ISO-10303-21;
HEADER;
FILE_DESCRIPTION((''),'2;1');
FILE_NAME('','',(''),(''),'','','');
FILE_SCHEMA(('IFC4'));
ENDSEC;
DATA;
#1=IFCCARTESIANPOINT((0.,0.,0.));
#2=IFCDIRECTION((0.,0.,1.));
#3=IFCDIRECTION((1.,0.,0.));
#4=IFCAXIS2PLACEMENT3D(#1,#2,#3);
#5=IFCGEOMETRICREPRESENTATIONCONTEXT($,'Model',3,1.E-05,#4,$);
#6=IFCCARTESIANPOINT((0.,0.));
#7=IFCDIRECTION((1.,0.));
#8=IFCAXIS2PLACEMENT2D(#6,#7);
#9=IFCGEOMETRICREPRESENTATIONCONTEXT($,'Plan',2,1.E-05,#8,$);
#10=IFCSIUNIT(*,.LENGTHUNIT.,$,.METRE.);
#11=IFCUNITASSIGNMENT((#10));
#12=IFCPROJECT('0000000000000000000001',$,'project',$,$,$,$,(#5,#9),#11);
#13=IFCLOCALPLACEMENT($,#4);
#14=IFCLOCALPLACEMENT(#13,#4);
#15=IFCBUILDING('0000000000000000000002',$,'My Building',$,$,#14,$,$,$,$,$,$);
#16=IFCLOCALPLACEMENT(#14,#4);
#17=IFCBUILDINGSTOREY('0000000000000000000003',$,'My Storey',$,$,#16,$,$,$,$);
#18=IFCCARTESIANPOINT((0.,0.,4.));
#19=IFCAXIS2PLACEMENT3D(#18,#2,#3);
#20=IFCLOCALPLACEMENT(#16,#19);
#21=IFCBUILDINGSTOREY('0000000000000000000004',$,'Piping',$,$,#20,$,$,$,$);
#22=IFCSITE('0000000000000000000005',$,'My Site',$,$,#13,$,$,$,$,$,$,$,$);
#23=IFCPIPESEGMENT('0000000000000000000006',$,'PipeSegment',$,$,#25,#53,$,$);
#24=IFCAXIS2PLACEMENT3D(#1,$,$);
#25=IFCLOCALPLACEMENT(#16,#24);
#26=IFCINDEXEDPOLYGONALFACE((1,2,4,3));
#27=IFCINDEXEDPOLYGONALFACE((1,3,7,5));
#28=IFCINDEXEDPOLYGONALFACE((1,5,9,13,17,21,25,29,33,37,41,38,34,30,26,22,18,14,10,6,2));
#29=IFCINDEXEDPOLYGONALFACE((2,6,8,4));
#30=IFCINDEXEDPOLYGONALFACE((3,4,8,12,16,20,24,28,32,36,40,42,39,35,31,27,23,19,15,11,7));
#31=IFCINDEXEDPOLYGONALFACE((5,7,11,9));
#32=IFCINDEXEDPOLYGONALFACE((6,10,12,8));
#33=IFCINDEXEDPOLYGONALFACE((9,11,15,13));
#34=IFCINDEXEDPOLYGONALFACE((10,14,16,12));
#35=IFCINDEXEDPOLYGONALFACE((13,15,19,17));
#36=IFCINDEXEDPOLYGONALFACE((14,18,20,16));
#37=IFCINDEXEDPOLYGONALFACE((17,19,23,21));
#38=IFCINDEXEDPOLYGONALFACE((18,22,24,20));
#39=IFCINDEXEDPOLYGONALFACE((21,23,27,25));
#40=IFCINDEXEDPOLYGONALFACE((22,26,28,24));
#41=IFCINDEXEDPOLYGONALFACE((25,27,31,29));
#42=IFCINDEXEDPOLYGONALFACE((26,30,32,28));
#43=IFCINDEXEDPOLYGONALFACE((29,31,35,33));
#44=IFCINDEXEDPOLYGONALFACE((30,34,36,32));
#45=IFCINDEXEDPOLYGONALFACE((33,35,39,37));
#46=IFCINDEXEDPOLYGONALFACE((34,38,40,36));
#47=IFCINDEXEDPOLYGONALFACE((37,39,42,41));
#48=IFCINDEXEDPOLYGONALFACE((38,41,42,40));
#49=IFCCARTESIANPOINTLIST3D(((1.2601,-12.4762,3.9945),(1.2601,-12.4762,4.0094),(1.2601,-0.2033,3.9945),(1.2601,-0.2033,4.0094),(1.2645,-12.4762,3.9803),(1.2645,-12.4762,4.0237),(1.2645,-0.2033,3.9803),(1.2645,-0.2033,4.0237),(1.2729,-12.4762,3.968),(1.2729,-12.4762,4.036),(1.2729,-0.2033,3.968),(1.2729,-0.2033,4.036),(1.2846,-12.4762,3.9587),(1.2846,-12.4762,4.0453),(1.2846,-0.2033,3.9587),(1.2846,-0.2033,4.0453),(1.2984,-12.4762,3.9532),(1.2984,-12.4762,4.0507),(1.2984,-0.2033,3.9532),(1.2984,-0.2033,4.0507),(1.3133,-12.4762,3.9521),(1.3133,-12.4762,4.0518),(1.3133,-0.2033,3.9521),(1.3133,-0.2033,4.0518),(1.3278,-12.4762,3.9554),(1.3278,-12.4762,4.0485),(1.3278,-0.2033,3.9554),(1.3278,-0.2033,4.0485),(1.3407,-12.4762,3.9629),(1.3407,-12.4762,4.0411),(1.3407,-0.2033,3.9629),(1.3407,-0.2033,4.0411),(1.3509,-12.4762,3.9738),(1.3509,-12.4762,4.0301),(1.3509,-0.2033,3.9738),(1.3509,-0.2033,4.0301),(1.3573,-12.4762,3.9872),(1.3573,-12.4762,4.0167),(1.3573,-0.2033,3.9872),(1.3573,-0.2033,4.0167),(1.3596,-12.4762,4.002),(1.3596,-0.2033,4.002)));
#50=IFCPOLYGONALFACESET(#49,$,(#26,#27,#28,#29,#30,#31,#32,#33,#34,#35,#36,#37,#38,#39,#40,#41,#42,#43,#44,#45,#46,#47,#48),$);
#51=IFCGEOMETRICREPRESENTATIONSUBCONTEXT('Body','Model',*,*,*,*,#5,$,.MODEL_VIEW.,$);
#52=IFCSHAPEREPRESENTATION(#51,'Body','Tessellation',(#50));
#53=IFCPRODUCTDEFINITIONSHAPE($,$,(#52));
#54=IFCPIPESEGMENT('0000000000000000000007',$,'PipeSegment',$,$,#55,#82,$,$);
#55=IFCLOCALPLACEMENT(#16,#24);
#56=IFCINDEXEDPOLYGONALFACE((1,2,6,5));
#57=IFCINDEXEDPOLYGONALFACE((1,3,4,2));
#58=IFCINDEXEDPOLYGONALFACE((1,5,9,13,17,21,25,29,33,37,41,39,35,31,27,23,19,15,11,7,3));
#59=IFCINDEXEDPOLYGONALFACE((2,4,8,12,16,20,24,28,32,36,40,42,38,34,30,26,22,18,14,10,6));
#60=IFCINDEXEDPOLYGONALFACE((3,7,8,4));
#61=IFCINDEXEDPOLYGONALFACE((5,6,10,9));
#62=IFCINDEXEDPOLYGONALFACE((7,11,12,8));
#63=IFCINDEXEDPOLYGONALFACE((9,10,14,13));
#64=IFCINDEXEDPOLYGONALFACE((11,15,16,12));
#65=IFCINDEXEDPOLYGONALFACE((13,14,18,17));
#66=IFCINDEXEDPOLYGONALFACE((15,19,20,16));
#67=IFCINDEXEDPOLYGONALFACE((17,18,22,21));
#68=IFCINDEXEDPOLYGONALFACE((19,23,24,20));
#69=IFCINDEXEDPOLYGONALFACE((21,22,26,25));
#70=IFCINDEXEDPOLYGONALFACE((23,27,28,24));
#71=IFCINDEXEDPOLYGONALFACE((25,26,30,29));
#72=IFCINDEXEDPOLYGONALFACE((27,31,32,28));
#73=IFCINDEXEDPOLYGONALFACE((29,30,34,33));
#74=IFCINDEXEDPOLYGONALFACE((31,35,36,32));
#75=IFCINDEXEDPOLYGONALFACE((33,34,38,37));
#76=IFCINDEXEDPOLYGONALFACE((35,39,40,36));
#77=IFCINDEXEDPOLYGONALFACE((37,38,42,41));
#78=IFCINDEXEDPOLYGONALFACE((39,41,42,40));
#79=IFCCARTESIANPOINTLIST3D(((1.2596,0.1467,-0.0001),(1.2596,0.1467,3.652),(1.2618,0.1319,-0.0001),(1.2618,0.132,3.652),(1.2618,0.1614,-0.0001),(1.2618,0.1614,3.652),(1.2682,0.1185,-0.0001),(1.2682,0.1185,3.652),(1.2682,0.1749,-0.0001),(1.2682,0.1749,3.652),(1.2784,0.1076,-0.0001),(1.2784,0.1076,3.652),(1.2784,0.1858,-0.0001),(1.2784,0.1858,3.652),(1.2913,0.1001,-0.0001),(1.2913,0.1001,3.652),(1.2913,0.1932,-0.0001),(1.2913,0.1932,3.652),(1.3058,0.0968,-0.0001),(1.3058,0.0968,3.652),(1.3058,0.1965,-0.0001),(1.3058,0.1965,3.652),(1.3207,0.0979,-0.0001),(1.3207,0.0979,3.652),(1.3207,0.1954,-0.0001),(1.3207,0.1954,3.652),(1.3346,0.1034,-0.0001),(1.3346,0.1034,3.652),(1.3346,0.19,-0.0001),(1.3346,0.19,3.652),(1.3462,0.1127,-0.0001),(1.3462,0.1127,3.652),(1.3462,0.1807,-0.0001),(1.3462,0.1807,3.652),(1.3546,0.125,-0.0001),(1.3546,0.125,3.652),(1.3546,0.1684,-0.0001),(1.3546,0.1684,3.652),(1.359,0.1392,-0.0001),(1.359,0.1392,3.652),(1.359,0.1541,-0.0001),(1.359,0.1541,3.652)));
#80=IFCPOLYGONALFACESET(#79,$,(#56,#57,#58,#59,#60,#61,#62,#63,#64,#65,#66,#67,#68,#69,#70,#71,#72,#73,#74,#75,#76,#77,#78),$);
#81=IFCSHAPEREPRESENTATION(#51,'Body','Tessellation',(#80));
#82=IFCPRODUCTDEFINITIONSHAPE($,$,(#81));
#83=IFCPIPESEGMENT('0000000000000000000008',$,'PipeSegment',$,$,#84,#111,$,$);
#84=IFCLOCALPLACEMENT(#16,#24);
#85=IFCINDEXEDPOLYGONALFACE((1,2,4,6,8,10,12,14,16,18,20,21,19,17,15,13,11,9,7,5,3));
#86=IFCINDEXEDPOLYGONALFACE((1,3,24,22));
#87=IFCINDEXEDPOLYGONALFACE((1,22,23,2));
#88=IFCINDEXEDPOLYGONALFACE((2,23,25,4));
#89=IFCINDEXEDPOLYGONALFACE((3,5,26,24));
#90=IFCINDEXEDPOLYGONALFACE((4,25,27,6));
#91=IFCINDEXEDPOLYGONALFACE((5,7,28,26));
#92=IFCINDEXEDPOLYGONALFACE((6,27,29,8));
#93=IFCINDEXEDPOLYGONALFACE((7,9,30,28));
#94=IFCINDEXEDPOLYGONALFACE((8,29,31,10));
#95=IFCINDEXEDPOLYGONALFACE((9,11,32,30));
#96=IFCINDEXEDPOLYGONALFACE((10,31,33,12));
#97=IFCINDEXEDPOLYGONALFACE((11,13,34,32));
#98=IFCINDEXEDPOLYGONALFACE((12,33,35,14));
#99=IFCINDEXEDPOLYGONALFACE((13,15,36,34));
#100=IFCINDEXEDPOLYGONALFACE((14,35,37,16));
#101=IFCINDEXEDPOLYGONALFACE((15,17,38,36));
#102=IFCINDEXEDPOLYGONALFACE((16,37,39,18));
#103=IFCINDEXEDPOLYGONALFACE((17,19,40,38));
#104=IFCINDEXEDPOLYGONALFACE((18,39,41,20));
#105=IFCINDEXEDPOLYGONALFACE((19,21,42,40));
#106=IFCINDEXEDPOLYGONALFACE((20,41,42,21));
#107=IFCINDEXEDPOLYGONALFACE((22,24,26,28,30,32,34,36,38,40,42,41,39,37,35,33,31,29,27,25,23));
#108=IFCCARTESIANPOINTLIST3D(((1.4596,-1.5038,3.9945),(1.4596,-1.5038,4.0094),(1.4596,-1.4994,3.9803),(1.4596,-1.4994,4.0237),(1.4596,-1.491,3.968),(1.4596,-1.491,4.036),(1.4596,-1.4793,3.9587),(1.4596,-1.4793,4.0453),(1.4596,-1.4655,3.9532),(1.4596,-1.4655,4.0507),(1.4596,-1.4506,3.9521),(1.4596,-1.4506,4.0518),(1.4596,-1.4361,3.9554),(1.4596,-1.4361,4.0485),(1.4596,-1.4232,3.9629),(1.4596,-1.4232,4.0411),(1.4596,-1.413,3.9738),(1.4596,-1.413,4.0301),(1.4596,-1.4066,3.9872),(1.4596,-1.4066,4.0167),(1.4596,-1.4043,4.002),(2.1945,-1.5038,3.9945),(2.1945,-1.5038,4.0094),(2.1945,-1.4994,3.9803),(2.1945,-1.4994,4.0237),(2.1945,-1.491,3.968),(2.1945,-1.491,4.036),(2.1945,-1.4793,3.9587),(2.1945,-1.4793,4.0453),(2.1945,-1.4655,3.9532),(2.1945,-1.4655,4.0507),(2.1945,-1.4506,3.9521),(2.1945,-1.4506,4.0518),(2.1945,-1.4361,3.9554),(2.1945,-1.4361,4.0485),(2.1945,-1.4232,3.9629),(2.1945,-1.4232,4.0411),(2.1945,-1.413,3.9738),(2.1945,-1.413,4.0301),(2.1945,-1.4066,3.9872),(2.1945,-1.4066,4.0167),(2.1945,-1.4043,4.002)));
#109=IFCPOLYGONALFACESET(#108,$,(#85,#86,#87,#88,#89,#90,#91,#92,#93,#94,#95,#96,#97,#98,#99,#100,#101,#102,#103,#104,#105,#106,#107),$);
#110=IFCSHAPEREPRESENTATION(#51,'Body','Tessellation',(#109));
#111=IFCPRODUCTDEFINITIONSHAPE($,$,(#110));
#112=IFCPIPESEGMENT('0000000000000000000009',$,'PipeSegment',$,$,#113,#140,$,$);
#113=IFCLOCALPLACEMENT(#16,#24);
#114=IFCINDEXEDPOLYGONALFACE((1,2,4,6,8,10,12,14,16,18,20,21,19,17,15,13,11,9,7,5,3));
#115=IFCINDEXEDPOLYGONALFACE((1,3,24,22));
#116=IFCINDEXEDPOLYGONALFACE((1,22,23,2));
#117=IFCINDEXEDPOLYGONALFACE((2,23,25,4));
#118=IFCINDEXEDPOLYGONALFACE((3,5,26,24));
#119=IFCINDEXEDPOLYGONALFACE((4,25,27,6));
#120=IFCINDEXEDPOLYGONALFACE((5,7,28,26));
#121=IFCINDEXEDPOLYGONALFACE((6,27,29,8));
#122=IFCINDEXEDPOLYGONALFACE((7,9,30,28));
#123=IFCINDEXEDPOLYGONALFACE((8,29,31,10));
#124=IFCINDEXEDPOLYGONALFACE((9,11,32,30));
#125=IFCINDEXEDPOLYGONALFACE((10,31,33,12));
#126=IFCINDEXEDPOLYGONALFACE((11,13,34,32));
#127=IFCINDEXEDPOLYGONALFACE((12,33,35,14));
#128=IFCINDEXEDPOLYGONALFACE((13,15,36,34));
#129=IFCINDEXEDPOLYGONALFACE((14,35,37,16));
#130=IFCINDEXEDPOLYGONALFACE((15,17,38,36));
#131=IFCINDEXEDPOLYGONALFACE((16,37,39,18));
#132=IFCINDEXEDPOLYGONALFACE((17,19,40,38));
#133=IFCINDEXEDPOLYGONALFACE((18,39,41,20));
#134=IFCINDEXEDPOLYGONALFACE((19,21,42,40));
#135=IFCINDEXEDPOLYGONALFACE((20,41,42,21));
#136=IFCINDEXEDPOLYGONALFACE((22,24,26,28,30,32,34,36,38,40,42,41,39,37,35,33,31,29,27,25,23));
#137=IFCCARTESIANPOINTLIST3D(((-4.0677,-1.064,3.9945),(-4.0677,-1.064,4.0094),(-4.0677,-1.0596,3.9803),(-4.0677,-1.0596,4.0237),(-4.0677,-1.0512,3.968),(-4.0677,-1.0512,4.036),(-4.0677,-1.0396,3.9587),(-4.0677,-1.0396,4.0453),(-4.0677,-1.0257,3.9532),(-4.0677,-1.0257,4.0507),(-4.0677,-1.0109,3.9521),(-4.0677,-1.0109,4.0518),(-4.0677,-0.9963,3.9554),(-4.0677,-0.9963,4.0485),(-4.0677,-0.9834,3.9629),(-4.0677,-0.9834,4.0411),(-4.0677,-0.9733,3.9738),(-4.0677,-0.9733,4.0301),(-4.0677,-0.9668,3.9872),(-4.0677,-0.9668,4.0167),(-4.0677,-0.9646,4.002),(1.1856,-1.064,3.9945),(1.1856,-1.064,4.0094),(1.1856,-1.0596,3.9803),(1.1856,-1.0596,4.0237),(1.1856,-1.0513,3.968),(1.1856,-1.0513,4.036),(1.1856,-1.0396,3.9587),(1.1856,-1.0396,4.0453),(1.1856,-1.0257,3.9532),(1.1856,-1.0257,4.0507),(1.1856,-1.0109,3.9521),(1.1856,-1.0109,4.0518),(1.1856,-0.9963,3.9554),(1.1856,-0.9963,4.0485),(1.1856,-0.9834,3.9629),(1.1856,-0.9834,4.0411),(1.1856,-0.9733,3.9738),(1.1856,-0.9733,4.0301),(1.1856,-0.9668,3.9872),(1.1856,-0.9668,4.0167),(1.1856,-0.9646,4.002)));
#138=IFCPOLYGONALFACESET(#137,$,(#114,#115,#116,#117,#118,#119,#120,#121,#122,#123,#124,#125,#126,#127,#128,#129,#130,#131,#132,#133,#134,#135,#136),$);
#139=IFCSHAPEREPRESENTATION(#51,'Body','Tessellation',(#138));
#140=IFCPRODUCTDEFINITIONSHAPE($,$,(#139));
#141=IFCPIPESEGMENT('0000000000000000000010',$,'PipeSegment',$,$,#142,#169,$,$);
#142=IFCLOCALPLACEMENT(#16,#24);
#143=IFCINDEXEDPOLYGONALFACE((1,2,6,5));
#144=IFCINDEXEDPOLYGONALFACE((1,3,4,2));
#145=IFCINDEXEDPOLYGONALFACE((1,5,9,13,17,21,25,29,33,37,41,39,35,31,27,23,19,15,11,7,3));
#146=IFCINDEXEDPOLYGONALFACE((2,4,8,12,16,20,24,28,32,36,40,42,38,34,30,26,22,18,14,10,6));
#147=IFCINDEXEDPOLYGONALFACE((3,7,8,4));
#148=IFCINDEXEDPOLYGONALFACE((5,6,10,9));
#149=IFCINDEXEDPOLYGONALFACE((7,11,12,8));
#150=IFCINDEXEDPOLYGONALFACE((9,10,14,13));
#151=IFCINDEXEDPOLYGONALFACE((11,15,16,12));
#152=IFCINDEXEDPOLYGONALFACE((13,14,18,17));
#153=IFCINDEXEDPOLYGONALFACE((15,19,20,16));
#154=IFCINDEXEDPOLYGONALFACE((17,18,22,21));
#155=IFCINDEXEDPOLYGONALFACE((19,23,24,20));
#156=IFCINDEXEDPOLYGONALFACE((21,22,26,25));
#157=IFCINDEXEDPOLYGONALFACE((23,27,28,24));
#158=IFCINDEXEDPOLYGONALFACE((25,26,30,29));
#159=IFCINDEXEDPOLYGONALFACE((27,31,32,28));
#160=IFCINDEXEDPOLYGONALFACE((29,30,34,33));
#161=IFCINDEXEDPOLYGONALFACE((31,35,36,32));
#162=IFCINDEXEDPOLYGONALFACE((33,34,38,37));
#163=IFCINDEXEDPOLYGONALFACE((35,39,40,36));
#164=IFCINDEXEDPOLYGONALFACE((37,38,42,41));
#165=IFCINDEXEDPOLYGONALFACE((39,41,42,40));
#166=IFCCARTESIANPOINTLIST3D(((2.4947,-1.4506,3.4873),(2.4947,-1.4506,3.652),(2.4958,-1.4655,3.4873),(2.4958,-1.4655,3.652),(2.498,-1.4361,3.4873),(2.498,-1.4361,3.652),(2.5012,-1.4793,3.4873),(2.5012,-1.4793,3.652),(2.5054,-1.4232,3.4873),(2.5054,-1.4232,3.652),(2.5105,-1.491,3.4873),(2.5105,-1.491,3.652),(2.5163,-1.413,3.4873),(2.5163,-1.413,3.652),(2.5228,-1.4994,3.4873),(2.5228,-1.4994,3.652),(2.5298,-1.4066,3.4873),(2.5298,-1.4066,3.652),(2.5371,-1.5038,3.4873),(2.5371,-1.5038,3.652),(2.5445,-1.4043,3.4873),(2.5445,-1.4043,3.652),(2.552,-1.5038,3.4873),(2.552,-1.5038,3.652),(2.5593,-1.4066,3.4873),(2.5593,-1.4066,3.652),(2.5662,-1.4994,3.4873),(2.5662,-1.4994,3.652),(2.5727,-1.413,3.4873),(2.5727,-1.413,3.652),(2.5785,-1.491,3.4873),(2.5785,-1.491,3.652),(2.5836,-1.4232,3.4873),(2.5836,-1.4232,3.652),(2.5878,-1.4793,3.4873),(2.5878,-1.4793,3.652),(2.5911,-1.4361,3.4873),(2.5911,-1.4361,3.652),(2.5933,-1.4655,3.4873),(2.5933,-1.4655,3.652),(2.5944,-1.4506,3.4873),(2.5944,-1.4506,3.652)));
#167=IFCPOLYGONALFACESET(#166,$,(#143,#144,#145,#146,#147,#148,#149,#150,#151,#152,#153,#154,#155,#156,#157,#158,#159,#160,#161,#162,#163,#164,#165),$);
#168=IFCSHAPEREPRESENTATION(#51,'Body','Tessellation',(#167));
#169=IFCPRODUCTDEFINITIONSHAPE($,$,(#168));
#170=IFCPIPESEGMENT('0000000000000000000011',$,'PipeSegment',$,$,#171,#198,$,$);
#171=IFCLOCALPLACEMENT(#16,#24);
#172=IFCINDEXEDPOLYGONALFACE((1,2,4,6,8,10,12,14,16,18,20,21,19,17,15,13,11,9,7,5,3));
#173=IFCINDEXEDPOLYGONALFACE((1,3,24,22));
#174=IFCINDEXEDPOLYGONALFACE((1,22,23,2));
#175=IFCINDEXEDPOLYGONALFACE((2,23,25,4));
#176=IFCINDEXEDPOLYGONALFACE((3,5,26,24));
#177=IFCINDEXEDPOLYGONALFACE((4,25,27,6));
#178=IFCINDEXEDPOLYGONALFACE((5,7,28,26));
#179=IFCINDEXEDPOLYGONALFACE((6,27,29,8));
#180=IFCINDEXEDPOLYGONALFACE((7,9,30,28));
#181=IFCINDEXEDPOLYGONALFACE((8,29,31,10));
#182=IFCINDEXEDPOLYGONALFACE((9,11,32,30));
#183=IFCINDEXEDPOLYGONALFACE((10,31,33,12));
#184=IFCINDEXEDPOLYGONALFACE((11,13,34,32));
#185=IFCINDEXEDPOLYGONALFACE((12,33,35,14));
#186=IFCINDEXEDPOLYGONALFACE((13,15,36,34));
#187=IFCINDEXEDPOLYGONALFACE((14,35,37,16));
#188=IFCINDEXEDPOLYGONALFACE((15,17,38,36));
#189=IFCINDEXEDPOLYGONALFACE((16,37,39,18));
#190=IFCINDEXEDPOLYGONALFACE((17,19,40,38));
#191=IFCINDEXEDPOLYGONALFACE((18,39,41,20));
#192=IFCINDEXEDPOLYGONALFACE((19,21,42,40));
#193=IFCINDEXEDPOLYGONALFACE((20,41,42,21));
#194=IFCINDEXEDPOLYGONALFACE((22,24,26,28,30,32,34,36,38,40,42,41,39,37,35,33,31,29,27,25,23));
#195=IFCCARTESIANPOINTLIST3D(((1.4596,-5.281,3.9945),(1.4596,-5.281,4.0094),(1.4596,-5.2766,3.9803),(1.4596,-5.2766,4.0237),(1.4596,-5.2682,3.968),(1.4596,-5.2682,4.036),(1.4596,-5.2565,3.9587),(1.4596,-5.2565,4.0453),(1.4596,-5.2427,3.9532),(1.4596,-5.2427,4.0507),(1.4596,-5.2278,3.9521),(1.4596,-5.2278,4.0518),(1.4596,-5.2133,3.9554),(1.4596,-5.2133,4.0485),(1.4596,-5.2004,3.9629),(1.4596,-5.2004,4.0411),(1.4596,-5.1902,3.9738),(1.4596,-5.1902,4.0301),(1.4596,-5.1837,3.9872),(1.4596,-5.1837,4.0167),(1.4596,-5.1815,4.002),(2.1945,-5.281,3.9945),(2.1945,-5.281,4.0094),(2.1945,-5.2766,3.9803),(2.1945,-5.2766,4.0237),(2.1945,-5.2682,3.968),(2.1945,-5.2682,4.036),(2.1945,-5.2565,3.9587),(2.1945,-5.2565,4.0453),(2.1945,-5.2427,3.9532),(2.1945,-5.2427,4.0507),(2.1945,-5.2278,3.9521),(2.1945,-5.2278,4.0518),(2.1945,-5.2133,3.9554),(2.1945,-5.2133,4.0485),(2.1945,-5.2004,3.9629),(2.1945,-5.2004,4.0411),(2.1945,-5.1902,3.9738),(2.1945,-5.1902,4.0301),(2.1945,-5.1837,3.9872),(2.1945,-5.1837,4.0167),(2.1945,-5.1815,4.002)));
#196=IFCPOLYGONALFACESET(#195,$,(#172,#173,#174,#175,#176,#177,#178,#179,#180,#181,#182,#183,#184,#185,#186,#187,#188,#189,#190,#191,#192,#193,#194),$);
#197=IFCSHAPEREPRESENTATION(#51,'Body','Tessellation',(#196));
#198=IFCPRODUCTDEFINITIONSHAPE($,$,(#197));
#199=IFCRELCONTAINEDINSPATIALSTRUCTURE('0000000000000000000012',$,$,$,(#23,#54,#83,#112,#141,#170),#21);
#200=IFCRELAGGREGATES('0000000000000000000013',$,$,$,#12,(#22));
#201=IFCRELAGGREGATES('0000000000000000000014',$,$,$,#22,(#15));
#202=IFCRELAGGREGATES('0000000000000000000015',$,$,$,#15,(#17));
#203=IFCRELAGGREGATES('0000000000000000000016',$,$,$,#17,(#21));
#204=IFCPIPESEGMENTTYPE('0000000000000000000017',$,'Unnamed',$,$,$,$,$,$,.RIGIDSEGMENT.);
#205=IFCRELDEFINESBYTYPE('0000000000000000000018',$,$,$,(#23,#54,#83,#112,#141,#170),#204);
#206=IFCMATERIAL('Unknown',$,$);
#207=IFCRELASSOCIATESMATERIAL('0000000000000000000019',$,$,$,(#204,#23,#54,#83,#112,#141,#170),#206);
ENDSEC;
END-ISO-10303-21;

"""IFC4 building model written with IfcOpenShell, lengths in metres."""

from ifc_helpers import new_model, si_unit, frame, origin_with_axes, origin_2d_with_axis, place, context, subcontext, project, spatial, circle, extrude, material, material_profile, profile_set, profile_usage, type_object, element, save


model = new_model("IFC4")

# Units and contexts
model_context = context("Model", 3, precision=1e-05, world=origin_with_axes())
plan_context = context("Plan", 2, precision=1e-05, world=origin_2d_with_axis())
body_context = subcontext(model_context, "Body", "Model", "MODEL_VIEW")
ifc_project = project(units=[si_unit("LENGTHUNIT", "METRE")], contexts=[model_context, plan_context])

# Site, building, storeys
site_placement = place(None, origin_with_axes())
site = spatial("IfcSite", under=ifc_project, at=site_placement, Name="My Site")
building_placement = place(site_placement, origin_with_axes())
building = spatial("IfcBuilding", under=site, at=building_placement, Name="My Building")
storey_1_placement = place(building_placement, origin_with_axes())
storey_1 = spatial("IfcBuildingStorey", under=building, at=storey_1_placement, Name="My Storey")
storey_2_placement = place(storey_1_placement, frame((0.0, 0.0, 4.0), z_axis=(0.0, 0.0, 1.0), x_axis=(1.0, 0.0, 0.0)))
storey_2 = spatial("IfcBuildingStorey", under=storey_1, at=storey_2_placement, Name="Piping")

# Pipe segments
ifc_material = material(Name="Unknown")
ifc_material_profile_1 = material_profile(ifc_material, circle(Radius=0.05))
ifc_profile_set_1 = profile_set([ifc_material_profile_1])
ifc_profile_usage_1 = profile_usage(ifc_profile_set_1, cardinal=5)
pipe_segment_type = type_object("IfcPipeSegmentType", Name="Unnamed", PredefinedType="RIGIDSEGMENT", material=ifc_profile_set_1)
pipe_segment_1_placement = place(storey_2_placement, frame((1.3096, -0.2033, 0.002), z_axis=(0.0, -1.0, 0.0), x_axis=(1.0, 0.0, 0.0)))
element("IfcPipeSegment", 1, at=pipe_segment_1_placement, inside=storey_2, type_object=pipe_segment_type, material=ifc_profile_usage_1, Name="PipeSegment", context=body_context, shape_type="SweptSolid", body=[
    extrude(circle(Radius=0.05), origin_with_axes(), (0.0, 0.0, 1.0), 12.2729),
])
ifc_profile_usage_2 = profile_usage(ifc_profile_set_1, cardinal=5)
pipe_segment_2_placement = place(storey_2_placement, frame((1.3096, 0.1467, -0.348), z_axis=(0.0, 0.0, -1.0), x_axis=(-1.0, 0.0, 0.0)))
element("IfcPipeSegment", 2, at=pipe_segment_2_placement, inside=storey_2, type_object=pipe_segment_type, material=ifc_profile_usage_2, Name="PipeSegment", context=body_context, shape_type="SweptSolid", body=[
    extrude(circle(Radius=0.05), origin_with_axes(), (0.0, 0.0, 1.0), 3.652),
])
ifc_profile_usage_3 = profile_usage(ifc_profile_set_1, cardinal=5)
pipe_segment_3_placement = place(storey_2_placement, frame((1.4596, -1.4543, 0.002), z_axis=(1.0, 0.0, 0.0), x_axis=(0.0, 1.0, 0.0)))
element("IfcPipeSegment", 3, at=pipe_segment_3_placement, inside=storey_2, type_object=pipe_segment_type, material=ifc_profile_usage_3, Name="PipeSegment", context=body_context, shape_type="SweptSolid", body=[
    extrude(circle(Radius=0.05), origin_with_axes(), (0.0, 0.0, 1.0), 0.735),
])
ifc_profile_usage_4 = profile_usage(ifc_profile_set_1, cardinal=5)
pipe_segment_4_placement = place(storey_2_placement, frame((-4.0677, -1.0146, 0.002), z_axis=(1.0, 0.0, 0.0), x_axis=(0.0, 1.0, 0.0)))
element("IfcPipeSegment", 4, at=pipe_segment_4_placement, inside=storey_2, type_object=pipe_segment_type, material=ifc_profile_usage_4, Name="PipeSegment", context=body_context, shape_type="SweptSolid", body=[
    extrude(circle(Radius=0.05), origin_with_axes(), (0.0, 0.0, 1.0), 5.2533),
])
ifc_profile_usage_5 = profile_usage(ifc_profile_set_1, cardinal=5)
pipe_segment_5_placement = place(storey_2_placement, frame((2.5445, -1.4543, -0.348), z_axis=(0.0, 0.0, -1.0), x_axis=(0.0, 1.0, 0.0)))
element("IfcPipeSegment", 5, at=pipe_segment_5_placement, inside=storey_2, type_object=pipe_segment_type, material=ifc_profile_usage_5, Name="PipeSegment", context=body_context, shape_type="SweptSolid", body=[
    extrude(circle(Radius=0.05), origin_with_axes(), (0.0, 0.0, 1.0), 0.1647),
])
ifc_profile_usage_6 = profile_usage(ifc_profile_set_1, cardinal=5)
pipe_segment_6_placement = place(storey_2_placement, frame((1.4596, -5.2315, 0.002), z_axis=(1.0, 0.0, 0.0), x_axis=(0.0, 1.0, 0.0)))
element("IfcPipeSegment", 6, at=pipe_segment_6_placement, inside=storey_2, type_object=pipe_segment_type, material=ifc_profile_usage_6, Name="PipeSegment", context=body_context, shape_type="SweptSolid", body=[
    extrude(circle(Radius=0.05), origin_with_axes(), (0.0, 0.0, 1.0), 0.735),
])

save(model, "model.ifc")
